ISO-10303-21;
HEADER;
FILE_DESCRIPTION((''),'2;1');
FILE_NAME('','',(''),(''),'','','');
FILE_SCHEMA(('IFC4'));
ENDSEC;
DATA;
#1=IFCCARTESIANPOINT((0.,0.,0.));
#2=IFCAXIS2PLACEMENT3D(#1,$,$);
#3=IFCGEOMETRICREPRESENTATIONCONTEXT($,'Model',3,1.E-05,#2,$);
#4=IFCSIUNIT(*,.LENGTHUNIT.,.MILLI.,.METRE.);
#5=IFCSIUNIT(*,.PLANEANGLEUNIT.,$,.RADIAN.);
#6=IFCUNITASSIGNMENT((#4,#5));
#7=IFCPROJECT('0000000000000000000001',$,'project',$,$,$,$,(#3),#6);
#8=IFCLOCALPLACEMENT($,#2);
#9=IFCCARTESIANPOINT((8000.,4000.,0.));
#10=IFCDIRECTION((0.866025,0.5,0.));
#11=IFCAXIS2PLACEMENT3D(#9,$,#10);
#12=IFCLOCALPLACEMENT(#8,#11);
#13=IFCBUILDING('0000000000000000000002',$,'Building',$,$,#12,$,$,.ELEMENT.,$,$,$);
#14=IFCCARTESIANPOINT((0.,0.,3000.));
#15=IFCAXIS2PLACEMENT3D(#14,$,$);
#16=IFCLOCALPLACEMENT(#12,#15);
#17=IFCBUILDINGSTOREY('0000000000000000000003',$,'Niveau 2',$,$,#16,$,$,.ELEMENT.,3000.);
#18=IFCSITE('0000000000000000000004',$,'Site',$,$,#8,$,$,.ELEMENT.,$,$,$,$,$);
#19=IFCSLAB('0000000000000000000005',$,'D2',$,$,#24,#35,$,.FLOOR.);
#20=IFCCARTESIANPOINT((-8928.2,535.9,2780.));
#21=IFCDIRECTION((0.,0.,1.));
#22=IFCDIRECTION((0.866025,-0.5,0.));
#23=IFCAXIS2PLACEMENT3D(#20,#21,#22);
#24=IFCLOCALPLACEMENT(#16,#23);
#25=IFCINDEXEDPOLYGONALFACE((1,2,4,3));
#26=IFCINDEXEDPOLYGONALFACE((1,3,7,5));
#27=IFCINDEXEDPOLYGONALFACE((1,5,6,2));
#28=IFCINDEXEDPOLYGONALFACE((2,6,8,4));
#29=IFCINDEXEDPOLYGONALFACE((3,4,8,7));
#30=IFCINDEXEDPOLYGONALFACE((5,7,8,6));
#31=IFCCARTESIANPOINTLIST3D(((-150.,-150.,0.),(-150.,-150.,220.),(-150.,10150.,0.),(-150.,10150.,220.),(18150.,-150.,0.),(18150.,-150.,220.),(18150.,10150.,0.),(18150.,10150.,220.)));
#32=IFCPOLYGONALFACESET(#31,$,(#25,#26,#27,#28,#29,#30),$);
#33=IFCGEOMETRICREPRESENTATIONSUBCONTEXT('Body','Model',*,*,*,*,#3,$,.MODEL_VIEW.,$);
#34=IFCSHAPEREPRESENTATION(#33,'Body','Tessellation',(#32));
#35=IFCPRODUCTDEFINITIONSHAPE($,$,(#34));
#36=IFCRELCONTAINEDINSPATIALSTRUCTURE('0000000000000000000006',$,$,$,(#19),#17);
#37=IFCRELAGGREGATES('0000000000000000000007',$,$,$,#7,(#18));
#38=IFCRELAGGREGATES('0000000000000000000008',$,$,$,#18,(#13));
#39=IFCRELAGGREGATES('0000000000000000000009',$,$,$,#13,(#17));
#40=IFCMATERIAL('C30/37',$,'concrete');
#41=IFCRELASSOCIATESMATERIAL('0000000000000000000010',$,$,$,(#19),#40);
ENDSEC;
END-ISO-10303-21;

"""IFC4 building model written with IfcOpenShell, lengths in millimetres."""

from ifc_helpers import new_model, si_unit, frame, origin, place, context, subcontext, project, spatial, polyline, outline, extrude, material, element, save


model = new_model("IFC4")

# Units and contexts
model_context = context("Model", 3, precision=1e-05, world=origin())
body_context = subcontext(model_context, "Body", "Model", "MODEL_VIEW")
ifc_project = project(units=[si_unit("LENGTHUNIT", "METRE", prefix="MILLI"), si_unit("PLANEANGLEUNIT", "RADIAN")], contexts=[model_context])

# Site, building, storey
site_placement = place(None, origin())
site = spatial("IfcSite", under=ifc_project, at=site_placement, Name="Site", CompositionType="ELEMENT")
building_placement = place(site_placement, frame((8000.0, 4000.0, 0.0), x_axis=(0.866025, 0.5, 0.0)))
building = spatial("IfcBuilding", under=site, at=building_placement, Name="Building", CompositionType="ELEMENT")
storey_placement = place(building_placement, frame((0.0, 0.0, 3000.0)))
storey = spatial("IfcBuildingStorey", under=building, at=storey_placement, Name="Niveau 2", CompositionType="ELEMENT", Elevation=3000.0)

# Shared definitions
ifc_material = material(Name="C30/37", Category="concrete")

# Slab
slab_placement = place(storey_placement, frame((-8928.2, 535.9, 2780.0), z_axis=(0.0, 0.0, 1.0), x_axis=(0.866025, -0.5, 0.0)))
element("IfcSlab", 1, at=slab_placement, inside=storey, material=ifc_material, Name="D2", PredefinedType="FLOOR", context=body_context, shape_type="SweptSolid", body=[
    extrude(outline(polyline([(-150.0, -150.0), (18150.0, -150.0), (18150.0, 10150.0), (-150.0, 10150.0), (-150.0, -150.0)])), origin(), (0.0, 0.0, 1.0), 220.0),
])

save(model, "model.ifc")
